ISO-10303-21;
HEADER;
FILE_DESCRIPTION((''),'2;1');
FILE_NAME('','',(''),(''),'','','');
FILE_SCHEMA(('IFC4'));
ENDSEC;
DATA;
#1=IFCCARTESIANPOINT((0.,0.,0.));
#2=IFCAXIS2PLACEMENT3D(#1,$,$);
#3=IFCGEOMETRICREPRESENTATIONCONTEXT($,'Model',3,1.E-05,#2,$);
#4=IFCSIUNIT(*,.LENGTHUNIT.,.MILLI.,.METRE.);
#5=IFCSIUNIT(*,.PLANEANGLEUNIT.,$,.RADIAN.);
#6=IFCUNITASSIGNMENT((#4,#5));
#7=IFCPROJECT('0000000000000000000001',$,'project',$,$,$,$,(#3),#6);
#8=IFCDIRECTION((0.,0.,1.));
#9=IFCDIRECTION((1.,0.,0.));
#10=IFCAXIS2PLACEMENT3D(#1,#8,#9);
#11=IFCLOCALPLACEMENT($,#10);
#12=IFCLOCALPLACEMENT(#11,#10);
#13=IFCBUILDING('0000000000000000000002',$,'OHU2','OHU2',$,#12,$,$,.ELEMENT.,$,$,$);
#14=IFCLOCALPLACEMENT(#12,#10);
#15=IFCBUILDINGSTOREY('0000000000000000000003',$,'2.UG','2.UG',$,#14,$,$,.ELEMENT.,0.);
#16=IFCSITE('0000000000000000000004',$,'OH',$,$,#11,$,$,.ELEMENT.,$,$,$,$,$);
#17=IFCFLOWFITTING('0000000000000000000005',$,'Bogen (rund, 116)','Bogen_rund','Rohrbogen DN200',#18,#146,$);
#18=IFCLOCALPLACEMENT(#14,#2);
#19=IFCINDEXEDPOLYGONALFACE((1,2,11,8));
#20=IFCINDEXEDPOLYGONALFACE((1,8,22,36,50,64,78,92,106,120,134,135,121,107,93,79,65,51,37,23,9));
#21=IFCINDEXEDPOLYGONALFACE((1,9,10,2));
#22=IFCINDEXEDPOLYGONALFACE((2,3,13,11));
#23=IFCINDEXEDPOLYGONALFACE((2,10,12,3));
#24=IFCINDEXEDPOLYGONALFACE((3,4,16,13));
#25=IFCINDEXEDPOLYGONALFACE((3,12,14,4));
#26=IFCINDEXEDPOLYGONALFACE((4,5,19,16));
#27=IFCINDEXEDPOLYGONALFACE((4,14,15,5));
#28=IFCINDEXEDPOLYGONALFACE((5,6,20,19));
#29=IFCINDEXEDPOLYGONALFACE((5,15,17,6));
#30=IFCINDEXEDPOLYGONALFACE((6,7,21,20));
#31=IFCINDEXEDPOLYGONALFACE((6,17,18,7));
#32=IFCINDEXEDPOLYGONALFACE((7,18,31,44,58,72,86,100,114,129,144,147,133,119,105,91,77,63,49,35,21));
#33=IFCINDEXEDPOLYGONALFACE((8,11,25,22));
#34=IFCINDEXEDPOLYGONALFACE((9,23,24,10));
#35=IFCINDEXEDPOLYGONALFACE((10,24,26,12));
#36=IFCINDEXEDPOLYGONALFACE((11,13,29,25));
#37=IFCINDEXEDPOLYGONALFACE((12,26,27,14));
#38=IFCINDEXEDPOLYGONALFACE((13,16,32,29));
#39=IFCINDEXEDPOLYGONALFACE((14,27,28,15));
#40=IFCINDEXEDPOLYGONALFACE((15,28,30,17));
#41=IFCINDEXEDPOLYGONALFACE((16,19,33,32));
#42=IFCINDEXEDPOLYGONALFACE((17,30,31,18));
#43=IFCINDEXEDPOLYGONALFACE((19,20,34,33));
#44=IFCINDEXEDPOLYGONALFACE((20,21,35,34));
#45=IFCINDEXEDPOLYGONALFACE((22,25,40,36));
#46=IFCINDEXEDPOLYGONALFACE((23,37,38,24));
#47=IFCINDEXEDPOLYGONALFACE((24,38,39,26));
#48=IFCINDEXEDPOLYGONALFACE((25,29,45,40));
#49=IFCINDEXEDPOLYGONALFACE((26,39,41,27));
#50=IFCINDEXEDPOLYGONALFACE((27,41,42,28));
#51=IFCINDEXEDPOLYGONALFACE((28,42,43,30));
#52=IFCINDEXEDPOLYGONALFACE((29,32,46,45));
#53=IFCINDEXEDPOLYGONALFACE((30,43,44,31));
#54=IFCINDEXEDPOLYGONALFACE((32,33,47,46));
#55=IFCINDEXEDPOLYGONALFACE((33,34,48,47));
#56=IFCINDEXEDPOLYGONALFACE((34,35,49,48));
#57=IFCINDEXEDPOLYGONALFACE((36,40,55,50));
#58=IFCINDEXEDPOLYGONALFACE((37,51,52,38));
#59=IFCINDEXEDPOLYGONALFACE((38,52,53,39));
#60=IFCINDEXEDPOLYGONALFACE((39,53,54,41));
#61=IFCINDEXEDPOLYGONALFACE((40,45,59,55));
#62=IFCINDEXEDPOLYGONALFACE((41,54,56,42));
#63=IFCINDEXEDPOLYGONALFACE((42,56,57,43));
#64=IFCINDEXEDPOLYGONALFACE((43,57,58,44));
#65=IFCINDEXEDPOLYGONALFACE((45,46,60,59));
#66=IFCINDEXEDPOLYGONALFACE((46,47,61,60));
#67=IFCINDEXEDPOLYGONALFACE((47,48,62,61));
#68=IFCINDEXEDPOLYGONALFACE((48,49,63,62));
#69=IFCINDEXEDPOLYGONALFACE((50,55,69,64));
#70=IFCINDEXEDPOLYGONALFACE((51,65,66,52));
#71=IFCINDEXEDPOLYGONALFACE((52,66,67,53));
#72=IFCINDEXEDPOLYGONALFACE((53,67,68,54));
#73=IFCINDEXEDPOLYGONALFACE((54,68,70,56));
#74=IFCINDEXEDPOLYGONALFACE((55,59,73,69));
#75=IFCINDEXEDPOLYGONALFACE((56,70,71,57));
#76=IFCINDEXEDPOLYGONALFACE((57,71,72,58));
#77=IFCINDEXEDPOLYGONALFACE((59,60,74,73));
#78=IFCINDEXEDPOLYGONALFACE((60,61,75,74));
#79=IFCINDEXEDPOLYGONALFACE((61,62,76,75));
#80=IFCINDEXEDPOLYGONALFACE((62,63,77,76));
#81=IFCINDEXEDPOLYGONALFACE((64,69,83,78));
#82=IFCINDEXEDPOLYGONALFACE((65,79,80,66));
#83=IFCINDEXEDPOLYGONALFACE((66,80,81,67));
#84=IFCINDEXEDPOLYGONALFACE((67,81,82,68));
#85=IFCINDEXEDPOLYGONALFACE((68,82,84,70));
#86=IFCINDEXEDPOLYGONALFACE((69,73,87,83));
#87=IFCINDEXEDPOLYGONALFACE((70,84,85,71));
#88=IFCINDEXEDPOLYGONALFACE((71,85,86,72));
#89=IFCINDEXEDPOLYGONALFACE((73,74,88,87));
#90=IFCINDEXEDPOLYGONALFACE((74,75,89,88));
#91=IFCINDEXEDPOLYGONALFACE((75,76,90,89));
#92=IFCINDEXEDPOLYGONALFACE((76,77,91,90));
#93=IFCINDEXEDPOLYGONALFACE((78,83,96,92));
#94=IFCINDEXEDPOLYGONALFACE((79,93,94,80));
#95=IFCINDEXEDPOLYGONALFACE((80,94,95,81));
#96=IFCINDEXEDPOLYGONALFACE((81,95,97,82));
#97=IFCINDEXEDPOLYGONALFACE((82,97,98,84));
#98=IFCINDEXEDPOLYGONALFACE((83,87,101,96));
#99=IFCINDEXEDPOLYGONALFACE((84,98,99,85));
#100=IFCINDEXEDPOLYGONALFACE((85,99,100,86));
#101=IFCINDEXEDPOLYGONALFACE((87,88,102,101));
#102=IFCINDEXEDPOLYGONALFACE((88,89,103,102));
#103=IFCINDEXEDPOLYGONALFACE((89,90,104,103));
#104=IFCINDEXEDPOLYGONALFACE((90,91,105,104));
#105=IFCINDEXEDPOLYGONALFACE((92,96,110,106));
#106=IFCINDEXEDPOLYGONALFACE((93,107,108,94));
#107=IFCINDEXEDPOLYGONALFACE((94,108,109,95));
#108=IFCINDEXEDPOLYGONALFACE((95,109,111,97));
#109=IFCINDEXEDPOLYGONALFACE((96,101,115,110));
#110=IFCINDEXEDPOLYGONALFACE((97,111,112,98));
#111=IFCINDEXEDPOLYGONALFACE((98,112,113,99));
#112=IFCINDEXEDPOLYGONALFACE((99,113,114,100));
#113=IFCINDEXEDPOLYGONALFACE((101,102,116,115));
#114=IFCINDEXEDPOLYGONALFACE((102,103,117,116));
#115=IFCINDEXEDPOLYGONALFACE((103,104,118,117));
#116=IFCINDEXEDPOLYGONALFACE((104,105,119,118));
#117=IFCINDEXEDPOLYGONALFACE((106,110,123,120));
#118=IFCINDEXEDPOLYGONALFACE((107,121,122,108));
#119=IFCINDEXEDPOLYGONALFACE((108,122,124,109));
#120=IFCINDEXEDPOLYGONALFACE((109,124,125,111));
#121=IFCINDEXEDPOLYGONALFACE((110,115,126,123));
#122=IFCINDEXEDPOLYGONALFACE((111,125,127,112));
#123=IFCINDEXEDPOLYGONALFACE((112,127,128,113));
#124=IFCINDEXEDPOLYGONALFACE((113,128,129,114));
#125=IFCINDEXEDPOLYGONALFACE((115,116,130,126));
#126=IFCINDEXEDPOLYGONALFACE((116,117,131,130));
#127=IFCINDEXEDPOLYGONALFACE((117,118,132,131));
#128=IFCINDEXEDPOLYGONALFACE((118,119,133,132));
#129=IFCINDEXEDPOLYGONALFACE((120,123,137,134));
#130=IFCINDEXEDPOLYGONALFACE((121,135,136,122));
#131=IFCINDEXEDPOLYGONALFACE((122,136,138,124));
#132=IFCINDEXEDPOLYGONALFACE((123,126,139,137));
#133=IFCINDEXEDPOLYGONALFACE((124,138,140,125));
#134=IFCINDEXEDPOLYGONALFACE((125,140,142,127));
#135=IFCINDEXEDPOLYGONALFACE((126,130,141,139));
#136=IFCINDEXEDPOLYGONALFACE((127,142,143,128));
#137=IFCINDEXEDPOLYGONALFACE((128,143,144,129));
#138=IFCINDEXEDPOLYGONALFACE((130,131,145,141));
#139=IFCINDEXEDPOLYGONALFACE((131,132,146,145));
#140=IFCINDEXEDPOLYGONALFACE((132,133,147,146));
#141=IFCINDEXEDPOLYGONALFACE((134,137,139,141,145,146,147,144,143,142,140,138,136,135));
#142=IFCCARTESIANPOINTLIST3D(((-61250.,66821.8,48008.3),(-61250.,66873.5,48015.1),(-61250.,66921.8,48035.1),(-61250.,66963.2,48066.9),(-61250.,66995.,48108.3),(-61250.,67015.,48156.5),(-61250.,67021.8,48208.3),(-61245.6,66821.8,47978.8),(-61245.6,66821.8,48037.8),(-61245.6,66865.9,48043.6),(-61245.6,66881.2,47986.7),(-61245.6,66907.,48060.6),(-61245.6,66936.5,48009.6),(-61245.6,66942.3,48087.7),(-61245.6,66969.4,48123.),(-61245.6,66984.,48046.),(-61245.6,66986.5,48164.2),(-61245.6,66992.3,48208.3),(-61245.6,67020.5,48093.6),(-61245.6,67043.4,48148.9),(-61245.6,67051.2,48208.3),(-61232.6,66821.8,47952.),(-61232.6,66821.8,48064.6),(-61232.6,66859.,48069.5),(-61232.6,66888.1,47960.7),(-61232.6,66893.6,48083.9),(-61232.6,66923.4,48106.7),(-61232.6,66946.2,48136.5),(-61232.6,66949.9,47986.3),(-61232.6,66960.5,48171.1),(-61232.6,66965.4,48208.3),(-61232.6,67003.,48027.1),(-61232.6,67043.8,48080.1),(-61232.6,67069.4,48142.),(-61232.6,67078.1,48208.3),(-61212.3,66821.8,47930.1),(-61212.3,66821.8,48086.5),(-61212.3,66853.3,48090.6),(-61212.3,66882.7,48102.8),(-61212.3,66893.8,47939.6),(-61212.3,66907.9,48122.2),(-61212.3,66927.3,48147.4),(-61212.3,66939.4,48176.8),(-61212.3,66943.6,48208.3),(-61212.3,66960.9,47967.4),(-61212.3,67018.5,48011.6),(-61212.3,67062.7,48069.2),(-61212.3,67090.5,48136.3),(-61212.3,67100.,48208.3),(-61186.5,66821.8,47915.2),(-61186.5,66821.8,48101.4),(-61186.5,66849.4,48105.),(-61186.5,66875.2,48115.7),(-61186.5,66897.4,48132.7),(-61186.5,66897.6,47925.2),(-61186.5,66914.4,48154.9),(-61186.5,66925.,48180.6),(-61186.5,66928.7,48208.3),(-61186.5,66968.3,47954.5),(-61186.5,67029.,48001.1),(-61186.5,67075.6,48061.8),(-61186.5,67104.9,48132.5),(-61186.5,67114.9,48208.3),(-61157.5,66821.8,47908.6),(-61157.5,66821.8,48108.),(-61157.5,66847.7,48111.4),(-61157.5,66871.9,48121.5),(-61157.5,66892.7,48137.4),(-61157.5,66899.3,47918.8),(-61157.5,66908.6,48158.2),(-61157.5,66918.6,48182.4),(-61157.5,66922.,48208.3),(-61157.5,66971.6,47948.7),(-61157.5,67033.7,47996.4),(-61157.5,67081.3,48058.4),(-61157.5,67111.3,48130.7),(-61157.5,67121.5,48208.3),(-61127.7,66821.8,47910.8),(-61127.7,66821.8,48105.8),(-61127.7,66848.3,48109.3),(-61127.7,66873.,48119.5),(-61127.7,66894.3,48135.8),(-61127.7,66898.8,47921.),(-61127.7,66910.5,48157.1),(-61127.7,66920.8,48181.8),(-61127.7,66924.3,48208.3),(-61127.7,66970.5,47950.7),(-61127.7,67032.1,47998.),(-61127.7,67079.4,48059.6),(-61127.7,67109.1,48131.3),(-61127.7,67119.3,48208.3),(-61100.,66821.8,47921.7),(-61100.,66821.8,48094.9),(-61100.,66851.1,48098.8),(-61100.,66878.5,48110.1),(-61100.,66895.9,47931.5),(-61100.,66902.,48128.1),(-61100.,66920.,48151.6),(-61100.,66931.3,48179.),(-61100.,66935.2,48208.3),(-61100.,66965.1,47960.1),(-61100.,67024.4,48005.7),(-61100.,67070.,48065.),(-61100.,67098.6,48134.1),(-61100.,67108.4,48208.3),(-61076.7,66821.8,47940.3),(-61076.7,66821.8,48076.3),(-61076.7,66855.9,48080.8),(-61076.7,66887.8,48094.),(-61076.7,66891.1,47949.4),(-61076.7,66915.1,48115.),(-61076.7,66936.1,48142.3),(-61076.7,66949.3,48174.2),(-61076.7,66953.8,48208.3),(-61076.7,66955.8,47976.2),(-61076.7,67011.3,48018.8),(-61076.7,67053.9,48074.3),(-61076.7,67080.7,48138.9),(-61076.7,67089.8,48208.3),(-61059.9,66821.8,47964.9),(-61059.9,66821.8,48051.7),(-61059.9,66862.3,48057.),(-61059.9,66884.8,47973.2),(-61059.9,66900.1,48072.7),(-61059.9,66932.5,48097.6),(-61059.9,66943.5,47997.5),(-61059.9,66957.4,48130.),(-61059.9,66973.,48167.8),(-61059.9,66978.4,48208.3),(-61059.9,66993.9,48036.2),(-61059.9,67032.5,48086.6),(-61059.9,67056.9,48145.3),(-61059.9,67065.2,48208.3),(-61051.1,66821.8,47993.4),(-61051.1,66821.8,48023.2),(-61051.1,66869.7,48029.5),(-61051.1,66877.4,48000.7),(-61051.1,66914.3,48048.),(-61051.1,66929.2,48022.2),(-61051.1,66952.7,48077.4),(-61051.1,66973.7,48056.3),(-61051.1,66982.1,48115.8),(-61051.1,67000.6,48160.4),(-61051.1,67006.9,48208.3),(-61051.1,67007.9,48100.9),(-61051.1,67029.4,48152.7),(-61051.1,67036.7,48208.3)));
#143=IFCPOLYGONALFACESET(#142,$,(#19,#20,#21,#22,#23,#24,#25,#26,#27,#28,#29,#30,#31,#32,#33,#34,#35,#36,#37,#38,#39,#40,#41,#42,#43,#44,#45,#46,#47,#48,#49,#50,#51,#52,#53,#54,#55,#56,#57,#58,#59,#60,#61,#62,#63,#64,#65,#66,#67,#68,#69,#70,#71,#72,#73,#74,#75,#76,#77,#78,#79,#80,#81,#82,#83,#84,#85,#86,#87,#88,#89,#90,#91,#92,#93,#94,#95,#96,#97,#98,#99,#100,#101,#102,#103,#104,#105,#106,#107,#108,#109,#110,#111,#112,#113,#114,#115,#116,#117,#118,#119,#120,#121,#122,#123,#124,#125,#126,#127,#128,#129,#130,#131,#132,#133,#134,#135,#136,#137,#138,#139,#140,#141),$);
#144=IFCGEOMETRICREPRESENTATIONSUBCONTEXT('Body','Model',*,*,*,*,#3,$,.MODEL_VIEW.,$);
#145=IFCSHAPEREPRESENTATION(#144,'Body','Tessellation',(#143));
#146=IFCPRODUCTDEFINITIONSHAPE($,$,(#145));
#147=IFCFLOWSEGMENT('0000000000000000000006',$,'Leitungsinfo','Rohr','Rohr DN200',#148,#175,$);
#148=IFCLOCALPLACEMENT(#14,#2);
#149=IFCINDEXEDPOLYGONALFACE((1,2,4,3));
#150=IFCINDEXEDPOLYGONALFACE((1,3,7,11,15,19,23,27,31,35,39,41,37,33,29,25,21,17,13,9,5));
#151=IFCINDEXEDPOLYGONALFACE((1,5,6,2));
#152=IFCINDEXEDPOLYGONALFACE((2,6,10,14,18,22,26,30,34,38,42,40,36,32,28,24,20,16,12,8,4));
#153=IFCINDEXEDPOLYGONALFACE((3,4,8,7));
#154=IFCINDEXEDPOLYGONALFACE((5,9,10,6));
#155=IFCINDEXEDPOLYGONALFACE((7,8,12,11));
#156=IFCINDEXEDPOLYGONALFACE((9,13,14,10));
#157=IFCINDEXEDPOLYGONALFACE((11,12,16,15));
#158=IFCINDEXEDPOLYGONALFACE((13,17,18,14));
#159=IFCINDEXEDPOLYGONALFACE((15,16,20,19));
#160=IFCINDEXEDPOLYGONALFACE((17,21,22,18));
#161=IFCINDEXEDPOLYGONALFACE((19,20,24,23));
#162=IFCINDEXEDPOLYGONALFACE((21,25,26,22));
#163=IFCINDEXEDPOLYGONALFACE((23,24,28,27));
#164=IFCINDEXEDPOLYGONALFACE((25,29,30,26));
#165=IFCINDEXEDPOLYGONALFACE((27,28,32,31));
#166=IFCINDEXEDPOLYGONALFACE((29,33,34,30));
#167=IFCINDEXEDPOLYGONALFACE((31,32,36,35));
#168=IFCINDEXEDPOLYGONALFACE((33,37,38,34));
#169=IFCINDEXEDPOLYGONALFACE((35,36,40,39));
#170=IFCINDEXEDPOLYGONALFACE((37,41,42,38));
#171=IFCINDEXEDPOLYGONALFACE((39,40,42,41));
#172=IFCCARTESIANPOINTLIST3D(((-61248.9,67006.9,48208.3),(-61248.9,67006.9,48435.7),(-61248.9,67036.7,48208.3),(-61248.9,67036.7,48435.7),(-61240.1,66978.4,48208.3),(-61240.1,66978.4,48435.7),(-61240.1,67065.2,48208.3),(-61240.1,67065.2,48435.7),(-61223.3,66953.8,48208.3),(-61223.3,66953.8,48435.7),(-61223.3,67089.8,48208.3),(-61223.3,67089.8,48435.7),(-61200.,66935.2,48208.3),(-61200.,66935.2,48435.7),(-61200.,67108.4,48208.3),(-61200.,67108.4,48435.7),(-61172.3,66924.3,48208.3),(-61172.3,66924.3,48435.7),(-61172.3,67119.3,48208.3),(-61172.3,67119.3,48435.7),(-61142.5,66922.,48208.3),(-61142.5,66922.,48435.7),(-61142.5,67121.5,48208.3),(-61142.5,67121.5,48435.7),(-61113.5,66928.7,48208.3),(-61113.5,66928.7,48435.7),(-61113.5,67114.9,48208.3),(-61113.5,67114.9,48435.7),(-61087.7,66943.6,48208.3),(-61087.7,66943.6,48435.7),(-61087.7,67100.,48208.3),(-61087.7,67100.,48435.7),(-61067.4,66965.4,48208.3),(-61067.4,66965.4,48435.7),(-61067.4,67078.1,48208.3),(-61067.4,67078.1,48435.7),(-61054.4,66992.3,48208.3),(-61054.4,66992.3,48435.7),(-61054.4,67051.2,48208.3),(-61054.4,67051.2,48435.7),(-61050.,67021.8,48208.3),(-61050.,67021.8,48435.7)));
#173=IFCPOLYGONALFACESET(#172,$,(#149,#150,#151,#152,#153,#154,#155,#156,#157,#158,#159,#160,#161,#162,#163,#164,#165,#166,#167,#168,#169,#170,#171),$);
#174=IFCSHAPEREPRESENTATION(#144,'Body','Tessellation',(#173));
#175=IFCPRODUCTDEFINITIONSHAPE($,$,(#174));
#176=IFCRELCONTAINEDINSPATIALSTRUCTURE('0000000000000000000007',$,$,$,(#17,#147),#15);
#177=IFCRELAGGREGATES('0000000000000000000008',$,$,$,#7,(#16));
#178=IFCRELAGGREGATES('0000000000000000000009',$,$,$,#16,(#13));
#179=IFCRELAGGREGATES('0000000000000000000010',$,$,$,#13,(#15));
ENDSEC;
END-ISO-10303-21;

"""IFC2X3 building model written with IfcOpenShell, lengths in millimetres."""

from ifc_helpers import new_model, entity, si_unit, frame, origin, origin_with_axes, origin_2d_with_axis, place, context, subcontext, project, spatial, circle, extrude, element, save


model = new_model("IFC2X3")

# Units and contexts
model_context = context("Model", 3, precision=1e-05, world=origin())
body_context = subcontext(model_context, "Body", "Model", "MODEL_VIEW")
ifc_project = project(units=[si_unit("LENGTHUNIT", "METRE", prefix="MILLI"), si_unit("PLANEANGLEUNIT", "RADIAN")], contexts=[model_context])

# Site, building, storey
site_placement = place(None, origin_with_axes())
site = spatial("IfcSite", under=ifc_project, at=site_placement, Name="OH", CompositionType="ELEMENT")
building_placement = place(site_placement, origin_with_axes())
building = spatial("IfcBuilding", under=site, at=building_placement, Name="OHU2", Description="OHU2", CompositionType="ELEMENT")
storey_placement = place(building_placement, origin_with_axes())
storey = spatial("IfcBuildingStorey", under=building, at=storey_placement, Name="2.UG", Description="2.UG", CompositionType="ELEMENT", Elevation=0.0)

# Flow fitting
flow_fitting_1_placement = place(storey_placement, frame((-61150.0, 66971.8, 48058.3), z_axis=(0.0, 0.0, 1.0), x_axis=(1.0, 0.0, 0.0)))
element("IfcFlowFitting", 1, at=flow_fitting_1_placement, inside=storey, Name="Bogen (rund, 116)", Description="Bogen_rund", ObjectType="Rohrbogen DN200", context=body_context, shape_type="SweptSolid", body=[
    entity("IfcRevolvedAreaSolid", entity("IfcCircleProfileDef", "AREA", None, entity("IfcAxis2Placement2D", entity("IfcCartesianPoint", [0.0, 0.0]), entity("IfcDirection", [1.0, 0.0])), 100.0), entity("IfcAxis2Placement3D", entity("IfcCartesianPoint", [0.0, -150.0, -50.0]), entity("IfcDirection", [0.0, 1.0, 0.0]), entity("IfcDirection", [-1.0, 0.0, 0.0])), entity("IfcAxis1Placement", entity("IfcCartesianPoint", [0.0, 200.0, 0.0]), entity("IfcDirection", [-1.0, 0.0, 0.0])), 1.570796),
])

# Flow segment
flow_segment_1_placement = place(storey_placement, frame((-61150.0, 67021.6, 48322.0), z_axis=(0.0, 0.0, 1.0), x_axis=(1.0, 0.0, 0.0)))
element("IfcFlowSegment", 2, at=flow_segment_1_placement, inside=storey, Name="Leitungsinfo", Description="Rohr", ObjectType="Rohr DN200", context=body_context, shape_type="SweptSolid", body=[
    extrude(circle(Radius=100.0, at=origin_2d_with_axis()), frame((0.0, 0.2, -113.7), z_axis=(0.0, 0.0, 1.0), x_axis=(1.0, 0.0, 0.0)), (0.0, 0.0, 1.0), 227.3),
])

save(model, "model.ifc")
